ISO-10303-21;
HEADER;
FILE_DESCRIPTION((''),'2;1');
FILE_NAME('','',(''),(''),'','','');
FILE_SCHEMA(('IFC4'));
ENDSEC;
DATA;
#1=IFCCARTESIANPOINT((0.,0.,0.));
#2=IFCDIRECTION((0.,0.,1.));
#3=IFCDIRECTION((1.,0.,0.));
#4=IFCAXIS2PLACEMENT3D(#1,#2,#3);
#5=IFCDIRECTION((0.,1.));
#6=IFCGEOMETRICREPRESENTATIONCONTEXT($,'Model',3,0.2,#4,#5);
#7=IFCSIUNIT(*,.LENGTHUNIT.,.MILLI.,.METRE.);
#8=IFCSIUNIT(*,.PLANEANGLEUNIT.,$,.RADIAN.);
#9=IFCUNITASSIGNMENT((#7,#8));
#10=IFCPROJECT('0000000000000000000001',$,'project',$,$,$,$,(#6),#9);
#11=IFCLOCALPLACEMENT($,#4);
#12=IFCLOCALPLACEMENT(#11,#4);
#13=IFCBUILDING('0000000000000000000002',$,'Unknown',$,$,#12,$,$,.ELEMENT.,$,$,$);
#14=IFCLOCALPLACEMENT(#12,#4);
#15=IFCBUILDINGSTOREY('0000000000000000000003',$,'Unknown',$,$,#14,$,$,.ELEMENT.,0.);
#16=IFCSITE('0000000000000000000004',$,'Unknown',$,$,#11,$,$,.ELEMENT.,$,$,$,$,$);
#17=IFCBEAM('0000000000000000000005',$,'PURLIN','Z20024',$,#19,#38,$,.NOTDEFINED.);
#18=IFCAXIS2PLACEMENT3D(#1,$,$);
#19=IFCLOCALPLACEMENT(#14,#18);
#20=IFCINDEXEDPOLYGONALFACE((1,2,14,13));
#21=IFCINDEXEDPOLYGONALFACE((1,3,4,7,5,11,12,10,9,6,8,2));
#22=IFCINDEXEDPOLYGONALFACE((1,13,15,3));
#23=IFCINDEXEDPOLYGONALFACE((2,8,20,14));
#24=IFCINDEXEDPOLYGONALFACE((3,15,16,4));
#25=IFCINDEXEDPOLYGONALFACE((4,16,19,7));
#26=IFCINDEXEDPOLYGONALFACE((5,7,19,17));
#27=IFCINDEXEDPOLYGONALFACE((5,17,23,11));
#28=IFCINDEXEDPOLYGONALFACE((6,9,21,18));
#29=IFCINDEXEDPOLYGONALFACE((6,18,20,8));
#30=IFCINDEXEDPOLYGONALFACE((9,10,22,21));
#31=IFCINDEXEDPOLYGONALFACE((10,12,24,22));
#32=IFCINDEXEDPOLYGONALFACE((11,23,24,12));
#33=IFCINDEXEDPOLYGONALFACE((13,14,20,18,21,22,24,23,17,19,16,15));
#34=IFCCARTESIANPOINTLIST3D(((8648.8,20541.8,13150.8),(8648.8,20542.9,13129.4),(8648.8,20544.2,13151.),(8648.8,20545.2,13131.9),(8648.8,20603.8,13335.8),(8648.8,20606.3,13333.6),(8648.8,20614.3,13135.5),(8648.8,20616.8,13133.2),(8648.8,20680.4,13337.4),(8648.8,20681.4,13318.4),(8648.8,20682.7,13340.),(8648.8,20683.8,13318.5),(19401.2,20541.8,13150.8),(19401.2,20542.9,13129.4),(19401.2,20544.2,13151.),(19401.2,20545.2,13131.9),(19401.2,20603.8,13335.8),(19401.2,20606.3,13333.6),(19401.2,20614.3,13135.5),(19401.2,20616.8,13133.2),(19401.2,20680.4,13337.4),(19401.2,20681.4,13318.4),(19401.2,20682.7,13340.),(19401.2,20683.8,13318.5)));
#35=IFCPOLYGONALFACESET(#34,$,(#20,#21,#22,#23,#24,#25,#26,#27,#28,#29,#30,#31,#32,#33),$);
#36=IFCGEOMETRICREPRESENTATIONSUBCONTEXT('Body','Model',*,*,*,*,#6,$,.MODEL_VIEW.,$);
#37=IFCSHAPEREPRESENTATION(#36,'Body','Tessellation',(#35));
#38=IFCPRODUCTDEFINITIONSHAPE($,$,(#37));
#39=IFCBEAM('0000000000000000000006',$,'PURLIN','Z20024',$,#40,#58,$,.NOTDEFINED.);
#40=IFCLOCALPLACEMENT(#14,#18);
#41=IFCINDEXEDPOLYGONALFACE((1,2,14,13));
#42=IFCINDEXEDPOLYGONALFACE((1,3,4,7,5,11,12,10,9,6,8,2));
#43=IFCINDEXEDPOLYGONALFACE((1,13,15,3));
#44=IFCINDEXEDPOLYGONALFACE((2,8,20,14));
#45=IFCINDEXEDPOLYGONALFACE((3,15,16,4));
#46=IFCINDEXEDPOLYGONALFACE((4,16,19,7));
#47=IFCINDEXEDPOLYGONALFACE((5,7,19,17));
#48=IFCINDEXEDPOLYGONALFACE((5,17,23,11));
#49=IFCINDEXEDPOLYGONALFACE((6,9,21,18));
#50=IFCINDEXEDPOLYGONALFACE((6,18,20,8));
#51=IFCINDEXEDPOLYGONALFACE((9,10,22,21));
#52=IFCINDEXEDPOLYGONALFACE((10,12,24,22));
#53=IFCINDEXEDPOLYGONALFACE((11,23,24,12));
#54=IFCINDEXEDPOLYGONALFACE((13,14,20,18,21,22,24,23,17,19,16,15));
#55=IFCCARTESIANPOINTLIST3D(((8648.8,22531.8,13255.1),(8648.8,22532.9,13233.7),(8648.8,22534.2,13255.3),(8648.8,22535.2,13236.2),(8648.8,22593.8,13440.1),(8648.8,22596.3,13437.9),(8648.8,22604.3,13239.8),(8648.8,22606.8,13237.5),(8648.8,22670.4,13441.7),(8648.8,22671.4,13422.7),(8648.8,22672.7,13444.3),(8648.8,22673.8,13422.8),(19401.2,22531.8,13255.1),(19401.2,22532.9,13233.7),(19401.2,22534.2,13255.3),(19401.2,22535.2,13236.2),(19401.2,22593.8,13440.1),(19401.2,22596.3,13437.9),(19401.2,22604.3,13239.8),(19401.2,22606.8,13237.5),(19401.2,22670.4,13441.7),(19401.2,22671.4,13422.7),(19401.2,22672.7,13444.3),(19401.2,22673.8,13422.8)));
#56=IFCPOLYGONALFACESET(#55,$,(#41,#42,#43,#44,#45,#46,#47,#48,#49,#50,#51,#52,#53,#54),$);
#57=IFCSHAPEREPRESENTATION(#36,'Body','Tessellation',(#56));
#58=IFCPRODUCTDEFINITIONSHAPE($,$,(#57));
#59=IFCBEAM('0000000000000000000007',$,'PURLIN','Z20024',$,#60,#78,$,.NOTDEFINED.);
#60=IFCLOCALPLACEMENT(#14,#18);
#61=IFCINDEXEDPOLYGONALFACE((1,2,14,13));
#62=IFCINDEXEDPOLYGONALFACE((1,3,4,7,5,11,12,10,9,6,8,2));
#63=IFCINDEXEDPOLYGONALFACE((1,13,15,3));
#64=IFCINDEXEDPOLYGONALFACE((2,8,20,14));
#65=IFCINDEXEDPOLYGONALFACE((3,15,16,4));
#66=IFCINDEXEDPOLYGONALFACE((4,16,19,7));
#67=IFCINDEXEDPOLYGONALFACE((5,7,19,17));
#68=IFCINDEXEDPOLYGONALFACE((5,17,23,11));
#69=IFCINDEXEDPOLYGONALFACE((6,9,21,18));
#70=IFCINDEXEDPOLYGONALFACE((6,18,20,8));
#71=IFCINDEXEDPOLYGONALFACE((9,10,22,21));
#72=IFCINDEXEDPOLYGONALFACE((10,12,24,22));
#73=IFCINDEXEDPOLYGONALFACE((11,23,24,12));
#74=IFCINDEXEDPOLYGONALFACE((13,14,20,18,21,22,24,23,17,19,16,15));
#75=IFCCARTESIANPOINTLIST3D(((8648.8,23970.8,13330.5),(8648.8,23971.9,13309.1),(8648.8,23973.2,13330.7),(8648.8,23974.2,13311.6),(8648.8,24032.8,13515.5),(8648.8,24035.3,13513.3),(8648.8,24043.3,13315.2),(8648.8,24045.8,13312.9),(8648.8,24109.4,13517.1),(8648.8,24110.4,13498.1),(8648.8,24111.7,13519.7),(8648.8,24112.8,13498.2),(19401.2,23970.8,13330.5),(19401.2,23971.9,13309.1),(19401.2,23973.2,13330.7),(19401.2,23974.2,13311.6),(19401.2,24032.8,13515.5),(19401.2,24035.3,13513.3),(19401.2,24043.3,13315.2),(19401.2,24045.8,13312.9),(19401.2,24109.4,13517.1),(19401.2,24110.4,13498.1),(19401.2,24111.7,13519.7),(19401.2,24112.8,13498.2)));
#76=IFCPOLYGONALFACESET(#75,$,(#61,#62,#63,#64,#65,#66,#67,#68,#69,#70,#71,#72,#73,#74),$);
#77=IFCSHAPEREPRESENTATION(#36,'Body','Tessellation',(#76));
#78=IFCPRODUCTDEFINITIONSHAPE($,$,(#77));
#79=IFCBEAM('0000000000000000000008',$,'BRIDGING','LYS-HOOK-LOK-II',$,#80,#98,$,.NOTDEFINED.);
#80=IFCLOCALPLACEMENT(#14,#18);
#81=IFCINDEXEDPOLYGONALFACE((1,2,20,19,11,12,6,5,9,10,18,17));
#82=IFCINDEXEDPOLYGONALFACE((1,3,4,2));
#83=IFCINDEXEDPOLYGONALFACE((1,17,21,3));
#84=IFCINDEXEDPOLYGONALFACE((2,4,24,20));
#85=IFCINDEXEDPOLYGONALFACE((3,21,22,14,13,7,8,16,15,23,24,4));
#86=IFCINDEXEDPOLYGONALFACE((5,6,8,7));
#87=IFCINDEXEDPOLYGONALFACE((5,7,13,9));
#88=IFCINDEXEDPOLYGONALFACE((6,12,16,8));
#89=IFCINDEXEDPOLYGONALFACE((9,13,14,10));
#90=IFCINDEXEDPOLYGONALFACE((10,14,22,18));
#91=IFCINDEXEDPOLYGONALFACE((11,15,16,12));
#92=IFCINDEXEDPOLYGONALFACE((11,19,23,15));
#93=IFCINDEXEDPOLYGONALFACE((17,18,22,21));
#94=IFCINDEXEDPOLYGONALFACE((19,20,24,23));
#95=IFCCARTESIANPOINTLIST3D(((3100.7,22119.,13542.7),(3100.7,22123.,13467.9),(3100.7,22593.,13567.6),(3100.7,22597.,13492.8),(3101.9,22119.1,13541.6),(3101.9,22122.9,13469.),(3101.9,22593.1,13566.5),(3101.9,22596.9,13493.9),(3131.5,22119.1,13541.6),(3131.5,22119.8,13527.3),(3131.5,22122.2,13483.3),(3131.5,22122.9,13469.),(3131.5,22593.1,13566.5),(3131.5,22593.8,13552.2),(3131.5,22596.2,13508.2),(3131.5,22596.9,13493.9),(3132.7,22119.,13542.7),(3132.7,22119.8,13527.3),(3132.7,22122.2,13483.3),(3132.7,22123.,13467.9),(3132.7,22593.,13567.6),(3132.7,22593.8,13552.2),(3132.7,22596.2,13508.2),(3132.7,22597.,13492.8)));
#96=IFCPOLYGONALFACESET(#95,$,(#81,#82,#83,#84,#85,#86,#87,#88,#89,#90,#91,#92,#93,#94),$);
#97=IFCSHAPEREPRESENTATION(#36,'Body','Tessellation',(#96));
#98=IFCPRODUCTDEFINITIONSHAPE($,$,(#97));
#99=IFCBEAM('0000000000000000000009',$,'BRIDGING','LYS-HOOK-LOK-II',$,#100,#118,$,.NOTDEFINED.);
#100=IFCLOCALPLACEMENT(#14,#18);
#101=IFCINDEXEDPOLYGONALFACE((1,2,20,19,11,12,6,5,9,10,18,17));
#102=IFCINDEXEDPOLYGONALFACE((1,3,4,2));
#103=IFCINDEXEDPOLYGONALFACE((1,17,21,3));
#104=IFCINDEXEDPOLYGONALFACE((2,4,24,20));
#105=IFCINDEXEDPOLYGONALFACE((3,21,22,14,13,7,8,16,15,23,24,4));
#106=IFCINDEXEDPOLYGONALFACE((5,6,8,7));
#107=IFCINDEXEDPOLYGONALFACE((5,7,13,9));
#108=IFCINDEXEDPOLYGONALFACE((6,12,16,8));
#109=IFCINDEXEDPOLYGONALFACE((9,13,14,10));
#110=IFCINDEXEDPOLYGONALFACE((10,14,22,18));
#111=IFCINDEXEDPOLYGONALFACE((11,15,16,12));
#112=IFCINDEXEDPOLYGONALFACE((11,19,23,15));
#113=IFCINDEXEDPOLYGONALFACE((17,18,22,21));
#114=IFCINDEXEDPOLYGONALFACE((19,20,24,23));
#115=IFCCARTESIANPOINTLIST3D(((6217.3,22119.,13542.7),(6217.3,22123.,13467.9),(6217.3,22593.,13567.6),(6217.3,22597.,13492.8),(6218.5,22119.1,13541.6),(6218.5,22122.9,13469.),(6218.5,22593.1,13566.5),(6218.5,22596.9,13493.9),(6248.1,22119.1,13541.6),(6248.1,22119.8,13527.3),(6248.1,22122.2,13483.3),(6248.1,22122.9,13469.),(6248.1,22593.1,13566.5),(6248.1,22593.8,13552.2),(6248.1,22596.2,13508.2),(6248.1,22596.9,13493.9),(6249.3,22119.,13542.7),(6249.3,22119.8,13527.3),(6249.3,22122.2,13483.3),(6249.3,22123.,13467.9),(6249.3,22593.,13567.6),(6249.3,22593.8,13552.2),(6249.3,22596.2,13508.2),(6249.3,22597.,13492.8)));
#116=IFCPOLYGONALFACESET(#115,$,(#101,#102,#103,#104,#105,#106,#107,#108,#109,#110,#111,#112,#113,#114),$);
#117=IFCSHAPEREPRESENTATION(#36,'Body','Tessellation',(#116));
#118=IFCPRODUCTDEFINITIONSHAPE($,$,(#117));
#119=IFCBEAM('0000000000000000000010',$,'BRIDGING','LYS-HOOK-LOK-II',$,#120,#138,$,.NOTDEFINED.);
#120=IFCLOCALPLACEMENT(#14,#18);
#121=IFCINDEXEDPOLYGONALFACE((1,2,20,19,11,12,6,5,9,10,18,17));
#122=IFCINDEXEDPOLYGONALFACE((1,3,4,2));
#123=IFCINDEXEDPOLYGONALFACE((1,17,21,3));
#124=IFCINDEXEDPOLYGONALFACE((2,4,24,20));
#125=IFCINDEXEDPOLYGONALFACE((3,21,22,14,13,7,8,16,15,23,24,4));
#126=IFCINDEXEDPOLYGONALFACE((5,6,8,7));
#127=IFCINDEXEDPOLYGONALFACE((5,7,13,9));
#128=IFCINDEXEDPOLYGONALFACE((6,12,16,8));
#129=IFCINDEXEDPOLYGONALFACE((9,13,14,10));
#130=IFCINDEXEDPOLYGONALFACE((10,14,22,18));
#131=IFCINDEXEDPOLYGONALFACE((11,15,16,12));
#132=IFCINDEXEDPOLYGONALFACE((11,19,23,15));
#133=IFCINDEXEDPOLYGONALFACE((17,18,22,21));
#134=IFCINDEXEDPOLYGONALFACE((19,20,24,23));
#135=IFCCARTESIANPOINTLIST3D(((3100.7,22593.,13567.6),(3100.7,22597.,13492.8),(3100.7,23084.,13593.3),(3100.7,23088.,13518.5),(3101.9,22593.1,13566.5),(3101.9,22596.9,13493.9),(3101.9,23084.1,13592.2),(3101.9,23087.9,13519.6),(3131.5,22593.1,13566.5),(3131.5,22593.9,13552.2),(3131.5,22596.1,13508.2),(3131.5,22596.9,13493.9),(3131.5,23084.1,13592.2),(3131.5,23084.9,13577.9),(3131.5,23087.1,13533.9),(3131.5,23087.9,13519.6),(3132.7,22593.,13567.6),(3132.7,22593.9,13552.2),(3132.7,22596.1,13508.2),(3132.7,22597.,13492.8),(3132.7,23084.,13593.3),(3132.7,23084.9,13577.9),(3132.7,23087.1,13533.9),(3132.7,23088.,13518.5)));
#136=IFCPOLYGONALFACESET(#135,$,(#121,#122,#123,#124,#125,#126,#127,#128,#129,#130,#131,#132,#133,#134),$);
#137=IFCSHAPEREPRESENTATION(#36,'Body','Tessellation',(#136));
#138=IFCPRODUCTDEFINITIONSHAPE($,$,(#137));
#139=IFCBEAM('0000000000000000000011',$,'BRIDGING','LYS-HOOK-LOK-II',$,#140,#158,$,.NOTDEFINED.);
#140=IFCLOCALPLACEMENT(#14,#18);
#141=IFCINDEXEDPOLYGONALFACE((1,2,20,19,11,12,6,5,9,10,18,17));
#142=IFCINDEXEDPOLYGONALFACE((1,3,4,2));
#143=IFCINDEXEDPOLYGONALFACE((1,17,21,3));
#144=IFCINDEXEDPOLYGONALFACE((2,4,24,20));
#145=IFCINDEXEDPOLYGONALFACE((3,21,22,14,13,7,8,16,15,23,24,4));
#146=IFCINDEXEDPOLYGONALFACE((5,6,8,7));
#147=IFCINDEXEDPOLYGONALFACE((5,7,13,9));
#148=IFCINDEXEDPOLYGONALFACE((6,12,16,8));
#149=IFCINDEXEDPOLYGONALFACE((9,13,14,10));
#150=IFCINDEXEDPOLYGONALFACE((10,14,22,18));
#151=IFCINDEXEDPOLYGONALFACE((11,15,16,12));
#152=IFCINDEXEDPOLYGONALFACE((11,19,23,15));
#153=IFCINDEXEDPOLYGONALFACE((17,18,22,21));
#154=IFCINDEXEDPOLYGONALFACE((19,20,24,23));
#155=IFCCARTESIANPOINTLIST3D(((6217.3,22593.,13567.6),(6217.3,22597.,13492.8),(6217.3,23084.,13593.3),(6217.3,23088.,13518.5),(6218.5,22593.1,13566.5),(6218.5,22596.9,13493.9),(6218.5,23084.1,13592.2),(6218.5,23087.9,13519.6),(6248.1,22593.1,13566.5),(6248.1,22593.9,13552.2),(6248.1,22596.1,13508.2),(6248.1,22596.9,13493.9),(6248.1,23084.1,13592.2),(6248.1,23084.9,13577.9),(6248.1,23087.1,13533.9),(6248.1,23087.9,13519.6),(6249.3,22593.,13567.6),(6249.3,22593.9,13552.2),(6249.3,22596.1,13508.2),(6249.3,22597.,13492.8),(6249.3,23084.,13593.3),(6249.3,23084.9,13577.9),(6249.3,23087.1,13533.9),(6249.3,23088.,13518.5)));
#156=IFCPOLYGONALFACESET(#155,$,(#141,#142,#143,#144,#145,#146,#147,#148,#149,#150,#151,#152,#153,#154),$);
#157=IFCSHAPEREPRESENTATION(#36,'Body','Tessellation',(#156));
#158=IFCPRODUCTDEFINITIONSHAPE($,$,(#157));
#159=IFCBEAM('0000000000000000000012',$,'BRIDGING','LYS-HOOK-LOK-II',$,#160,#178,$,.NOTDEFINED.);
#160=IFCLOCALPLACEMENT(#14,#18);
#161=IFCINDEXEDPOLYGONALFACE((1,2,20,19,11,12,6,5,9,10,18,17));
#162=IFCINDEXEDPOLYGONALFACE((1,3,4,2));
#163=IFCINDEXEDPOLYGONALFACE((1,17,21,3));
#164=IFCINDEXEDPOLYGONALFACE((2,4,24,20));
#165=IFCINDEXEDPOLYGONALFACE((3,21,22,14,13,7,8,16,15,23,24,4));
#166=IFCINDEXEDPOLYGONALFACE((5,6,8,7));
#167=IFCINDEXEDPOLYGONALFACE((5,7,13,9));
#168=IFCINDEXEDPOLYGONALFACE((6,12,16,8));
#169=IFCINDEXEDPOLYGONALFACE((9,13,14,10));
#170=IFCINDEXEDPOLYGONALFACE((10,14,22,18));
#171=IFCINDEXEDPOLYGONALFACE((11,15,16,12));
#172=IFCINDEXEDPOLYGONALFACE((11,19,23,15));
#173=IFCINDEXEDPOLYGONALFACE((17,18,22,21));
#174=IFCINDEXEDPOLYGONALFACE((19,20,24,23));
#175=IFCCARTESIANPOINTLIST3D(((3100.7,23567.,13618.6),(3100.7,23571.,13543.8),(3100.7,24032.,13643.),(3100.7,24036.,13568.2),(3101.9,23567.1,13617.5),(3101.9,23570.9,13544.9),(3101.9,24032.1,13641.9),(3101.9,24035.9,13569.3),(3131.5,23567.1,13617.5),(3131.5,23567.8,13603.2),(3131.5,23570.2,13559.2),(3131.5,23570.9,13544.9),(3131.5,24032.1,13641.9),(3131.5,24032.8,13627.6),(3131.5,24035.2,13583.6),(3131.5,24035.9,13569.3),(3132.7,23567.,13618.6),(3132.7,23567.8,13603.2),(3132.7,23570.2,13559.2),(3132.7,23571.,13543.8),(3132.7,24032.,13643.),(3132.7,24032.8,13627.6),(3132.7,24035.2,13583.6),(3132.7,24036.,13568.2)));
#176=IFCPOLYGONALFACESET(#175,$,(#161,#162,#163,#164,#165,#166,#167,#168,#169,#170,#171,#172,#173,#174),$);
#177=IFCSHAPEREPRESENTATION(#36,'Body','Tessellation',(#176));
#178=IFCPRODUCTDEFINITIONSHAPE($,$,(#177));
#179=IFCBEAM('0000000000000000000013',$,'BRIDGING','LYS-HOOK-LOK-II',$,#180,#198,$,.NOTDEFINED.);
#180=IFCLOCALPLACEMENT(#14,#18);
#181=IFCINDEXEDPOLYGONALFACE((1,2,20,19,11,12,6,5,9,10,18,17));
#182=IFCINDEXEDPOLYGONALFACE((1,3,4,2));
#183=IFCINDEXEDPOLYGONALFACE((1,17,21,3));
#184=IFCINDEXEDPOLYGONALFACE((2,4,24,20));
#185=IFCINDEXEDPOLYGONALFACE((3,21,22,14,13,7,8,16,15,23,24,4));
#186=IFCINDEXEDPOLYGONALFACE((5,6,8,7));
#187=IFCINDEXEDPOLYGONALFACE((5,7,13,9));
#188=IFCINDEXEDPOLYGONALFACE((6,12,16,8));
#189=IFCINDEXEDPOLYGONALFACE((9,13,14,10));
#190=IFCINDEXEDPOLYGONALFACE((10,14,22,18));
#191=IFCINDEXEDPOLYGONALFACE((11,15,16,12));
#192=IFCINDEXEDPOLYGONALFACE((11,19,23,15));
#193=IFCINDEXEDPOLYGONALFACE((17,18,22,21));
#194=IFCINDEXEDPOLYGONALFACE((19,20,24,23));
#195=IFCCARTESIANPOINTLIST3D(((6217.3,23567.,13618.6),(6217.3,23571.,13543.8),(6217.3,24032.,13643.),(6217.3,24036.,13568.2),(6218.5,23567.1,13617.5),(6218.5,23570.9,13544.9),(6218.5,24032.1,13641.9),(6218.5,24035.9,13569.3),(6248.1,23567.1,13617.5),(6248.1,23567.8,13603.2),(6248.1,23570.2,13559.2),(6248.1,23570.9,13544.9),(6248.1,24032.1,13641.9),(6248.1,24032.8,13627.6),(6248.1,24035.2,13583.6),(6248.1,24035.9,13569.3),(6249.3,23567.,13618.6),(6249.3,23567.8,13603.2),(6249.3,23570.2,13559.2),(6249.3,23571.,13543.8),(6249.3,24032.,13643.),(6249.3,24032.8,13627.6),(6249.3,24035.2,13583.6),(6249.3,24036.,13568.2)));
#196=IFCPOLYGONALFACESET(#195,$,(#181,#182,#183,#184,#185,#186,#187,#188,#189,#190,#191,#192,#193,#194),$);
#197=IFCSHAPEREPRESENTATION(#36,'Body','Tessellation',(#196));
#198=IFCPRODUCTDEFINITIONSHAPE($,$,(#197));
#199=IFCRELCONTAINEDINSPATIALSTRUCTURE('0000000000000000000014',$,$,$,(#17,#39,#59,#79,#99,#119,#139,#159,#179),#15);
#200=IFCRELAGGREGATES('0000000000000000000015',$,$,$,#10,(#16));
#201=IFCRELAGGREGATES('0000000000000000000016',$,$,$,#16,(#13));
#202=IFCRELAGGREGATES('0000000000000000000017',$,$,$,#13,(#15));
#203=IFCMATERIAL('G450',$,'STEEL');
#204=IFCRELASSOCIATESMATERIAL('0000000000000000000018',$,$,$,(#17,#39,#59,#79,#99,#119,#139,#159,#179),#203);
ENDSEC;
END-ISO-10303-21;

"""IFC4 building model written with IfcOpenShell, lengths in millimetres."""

from ifc_helpers import new_model, si_unit, direction, frame, origin_with_axes, place, context, subcontext, project, spatial, line, indexed_curve, outline, extrude, material, element, save


model = new_model("IFC4")

# Units and contexts
model_context = context("Model", 3, precision=0.2, world=origin_with_axes(), true_north=direction((0.0, 1.0)))
body_context = subcontext(model_context, "Body", "Model", "MODEL_VIEW")
ifc_project = project(units=[si_unit("LENGTHUNIT", "METRE", prefix="MILLI"), si_unit("PLANEANGLEUNIT", "RADIAN")], contexts=[model_context])

# Site, building, storey
site_placement = place(None, origin_with_axes())
site = spatial("IfcSite", under=ifc_project, at=site_placement, Name="Unknown", CompositionType="ELEMENT")
building_placement = place(site_placement, origin_with_axes())
building = spatial("IfcBuilding", under=site, at=building_placement, Name="Unknown", CompositionType="ELEMENT")
storey_placement = place(building_placement, origin_with_axes())
storey = spatial("IfcBuildingStorey", under=building, at=storey_placement, Name="Unknown", CompositionType="ELEMENT", Elevation=0.0)

# Beams
ifc_material_1 = material(Name="G450", Category="STEEL")
for number, where, z_axis, x_axis, name in (
    (1, (8648.8, 20610.3, 13234.5), (0.0, -0.99863, -0.052336), (1.0, 0.0, 0.0), "PURLIN"),
    (2, (8648.8, 22600.3, 13338.8), (0.0, -0.99863, -0.052336), (1.0, 0.0, 0.0), "PURLIN"),
    (3, (8648.8, 24039.3, 13414.2), (0.0, -0.99863, -0.052336), (1.0, 0.0, 0.0), "PURLIN"),
):
    element("IfcBeam", number, at=place(storey_placement, frame(where, z_axis=z_axis, x_axis=x_axis)), inside=storey, material=ifc_material_1, Name=name, Description="Z20024", PredefinedType="NOTDEFINED", context=body_context, shape_type="SolidModel", body=[
        extrude(outline(indexed_curve([(72.8, -101.5), (72.8, -80.0), (70.4, -80.0), (70.4, -99.1), (1.2, -99.1), (1.2, 101.5), (-77.8, 101.5), (-77.8, 80.0), (-75.4, 80.0), (-75.4, 99.1), (-1.2, 99.1), (-1.2, -101.5)], segments=[line(1, 2, 3, 4, 5, 6, 7, 8, 9, 10, 11, 12, 1)])), frame((0.0, 0.0, 0.0), z_axis=(-1.0, 0.0, 0.0), x_axis=(0.0, 0.0, 1.0)), (0.0, 0.0, -1.0), 10752.4),
    ])
for number, where, z_axis, x_axis, name in (
    (4, (3116.7, 22121.0, 13505.3), (1.0, 0.0, 0.0), (0.0, 0.998623, 0.052459), "BRIDGING"),
    (5, (6233.3, 22121.0, 13505.3), (1.0, 0.0, 0.0), (0.0, 0.998623, 0.052459), "BRIDGING"),
):
    element("IfcBeam", number, at=place(storey_placement, frame(where, z_axis=z_axis, x_axis=x_axis)), inside=storey, material=ifc_material_1, Name=name, Description="LYS-HOOK-LOK-II", PredefinedType="NOTDEFINED", context=body_context, shape_type="SolidModel", body=[
        extrude(outline(indexed_curve([(16.0, -37.5), (16.0, -22.0), (14.8, -22.0), (14.8, -36.3), (-14.8, -36.3), (-14.8, 36.3), (14.8, 36.3), (14.8, 22.0), (16.0, 22.0), (16.0, 37.5), (-16.0, 37.5), (-16.0, -37.5)], segments=[line(1, 2, 3, 4, 5, 6, 7, 8, 9, 10, 11, 12, 1)])), frame((0.0, 0.0, 0.0), z_axis=(-1.0, 0.0, 0.0), x_axis=(0.0, 0.0, 1.0)), (0.0, 0.0, -1.0), 474.7),
    ])
for number, where, z_axis, x_axis, name in (
    (6, (3116.7, 22595.0, 13530.2), (1.0, 0.0, 0.0), (0.0, 0.998633, 0.052271), "BRIDGING"),
    (7, (6233.3, 22595.0, 13530.2), (1.0, 0.0, 0.0), (0.0, 0.998633, 0.052271), "BRIDGING"),
):
    element("IfcBeam", number, at=place(storey_placement, frame(where, z_axis=z_axis, x_axis=x_axis)), inside=storey, material=ifc_material_1, Name=name, Description="LYS-HOOK-LOK-II", PredefinedType="NOTDEFINED", context=body_context, shape_type="SolidModel", body=[
        extrude(outline(indexed_curve([(16.0, -37.5), (16.0, -22.0), (14.8, -22.0), (14.8, -36.3), (-14.8, -36.3), (-14.8, 36.3), (14.8, 36.3), (14.8, 22.0), (16.0, 22.0), (16.0, 37.5), (-16.0, 37.5), (-16.0, -37.5)], segments=[line(1, 2, 3, 4, 5, 6, 7, 8, 9, 10, 11, 12, 1)])), frame((0.0, 0.0, 0.0), z_axis=(-1.0, 0.0, 0.0), x_axis=(0.0, 0.0, 1.0)), (0.0, 0.0, -1.0), 491.7),
    ])
for number, where, z_axis, x_axis, name in (
    (8, (3116.7, 23569.0, 13581.2), (1.0, 0.0, 0.0), (0.0, 0.998626, 0.052401), "BRIDGING"),
    (9, (6233.3, 23569.0, 13581.2), (1.0, 0.0, 0.0), (0.0, 0.998626, 0.052401), "BRIDGING"),
):
    element("IfcBeam", number, at=place(storey_placement, frame(where, z_axis=z_axis, x_axis=x_axis)), inside=storey, material=ifc_material_1, Name=name, Description="LYS-HOOK-LOK-II", PredefinedType="NOTDEFINED", context=body_context, shape_type="SolidModel", body=[
        extrude(outline(indexed_curve([(16.0, -37.5), (16.0, -22.0), (14.8, -22.0), (14.8, -36.3), (-14.8, -36.3), (-14.8, 36.3), (14.8, 36.3), (14.8, 22.0), (16.0, 22.0), (16.0, 37.5), (-16.0, 37.5), (-16.0, -37.5)], segments=[line(1, 2, 3, 4, 5, 6, 7, 8, 9, 10, 11, 12, 1)])), frame((0.0, 0.0, 0.0), z_axis=(-1.0, 0.0, 0.0), x_axis=(0.0, 0.0, 1.0)), (0.0, 0.0, -1.0), 465.6),
    ])

save(model, "model.ifc")
